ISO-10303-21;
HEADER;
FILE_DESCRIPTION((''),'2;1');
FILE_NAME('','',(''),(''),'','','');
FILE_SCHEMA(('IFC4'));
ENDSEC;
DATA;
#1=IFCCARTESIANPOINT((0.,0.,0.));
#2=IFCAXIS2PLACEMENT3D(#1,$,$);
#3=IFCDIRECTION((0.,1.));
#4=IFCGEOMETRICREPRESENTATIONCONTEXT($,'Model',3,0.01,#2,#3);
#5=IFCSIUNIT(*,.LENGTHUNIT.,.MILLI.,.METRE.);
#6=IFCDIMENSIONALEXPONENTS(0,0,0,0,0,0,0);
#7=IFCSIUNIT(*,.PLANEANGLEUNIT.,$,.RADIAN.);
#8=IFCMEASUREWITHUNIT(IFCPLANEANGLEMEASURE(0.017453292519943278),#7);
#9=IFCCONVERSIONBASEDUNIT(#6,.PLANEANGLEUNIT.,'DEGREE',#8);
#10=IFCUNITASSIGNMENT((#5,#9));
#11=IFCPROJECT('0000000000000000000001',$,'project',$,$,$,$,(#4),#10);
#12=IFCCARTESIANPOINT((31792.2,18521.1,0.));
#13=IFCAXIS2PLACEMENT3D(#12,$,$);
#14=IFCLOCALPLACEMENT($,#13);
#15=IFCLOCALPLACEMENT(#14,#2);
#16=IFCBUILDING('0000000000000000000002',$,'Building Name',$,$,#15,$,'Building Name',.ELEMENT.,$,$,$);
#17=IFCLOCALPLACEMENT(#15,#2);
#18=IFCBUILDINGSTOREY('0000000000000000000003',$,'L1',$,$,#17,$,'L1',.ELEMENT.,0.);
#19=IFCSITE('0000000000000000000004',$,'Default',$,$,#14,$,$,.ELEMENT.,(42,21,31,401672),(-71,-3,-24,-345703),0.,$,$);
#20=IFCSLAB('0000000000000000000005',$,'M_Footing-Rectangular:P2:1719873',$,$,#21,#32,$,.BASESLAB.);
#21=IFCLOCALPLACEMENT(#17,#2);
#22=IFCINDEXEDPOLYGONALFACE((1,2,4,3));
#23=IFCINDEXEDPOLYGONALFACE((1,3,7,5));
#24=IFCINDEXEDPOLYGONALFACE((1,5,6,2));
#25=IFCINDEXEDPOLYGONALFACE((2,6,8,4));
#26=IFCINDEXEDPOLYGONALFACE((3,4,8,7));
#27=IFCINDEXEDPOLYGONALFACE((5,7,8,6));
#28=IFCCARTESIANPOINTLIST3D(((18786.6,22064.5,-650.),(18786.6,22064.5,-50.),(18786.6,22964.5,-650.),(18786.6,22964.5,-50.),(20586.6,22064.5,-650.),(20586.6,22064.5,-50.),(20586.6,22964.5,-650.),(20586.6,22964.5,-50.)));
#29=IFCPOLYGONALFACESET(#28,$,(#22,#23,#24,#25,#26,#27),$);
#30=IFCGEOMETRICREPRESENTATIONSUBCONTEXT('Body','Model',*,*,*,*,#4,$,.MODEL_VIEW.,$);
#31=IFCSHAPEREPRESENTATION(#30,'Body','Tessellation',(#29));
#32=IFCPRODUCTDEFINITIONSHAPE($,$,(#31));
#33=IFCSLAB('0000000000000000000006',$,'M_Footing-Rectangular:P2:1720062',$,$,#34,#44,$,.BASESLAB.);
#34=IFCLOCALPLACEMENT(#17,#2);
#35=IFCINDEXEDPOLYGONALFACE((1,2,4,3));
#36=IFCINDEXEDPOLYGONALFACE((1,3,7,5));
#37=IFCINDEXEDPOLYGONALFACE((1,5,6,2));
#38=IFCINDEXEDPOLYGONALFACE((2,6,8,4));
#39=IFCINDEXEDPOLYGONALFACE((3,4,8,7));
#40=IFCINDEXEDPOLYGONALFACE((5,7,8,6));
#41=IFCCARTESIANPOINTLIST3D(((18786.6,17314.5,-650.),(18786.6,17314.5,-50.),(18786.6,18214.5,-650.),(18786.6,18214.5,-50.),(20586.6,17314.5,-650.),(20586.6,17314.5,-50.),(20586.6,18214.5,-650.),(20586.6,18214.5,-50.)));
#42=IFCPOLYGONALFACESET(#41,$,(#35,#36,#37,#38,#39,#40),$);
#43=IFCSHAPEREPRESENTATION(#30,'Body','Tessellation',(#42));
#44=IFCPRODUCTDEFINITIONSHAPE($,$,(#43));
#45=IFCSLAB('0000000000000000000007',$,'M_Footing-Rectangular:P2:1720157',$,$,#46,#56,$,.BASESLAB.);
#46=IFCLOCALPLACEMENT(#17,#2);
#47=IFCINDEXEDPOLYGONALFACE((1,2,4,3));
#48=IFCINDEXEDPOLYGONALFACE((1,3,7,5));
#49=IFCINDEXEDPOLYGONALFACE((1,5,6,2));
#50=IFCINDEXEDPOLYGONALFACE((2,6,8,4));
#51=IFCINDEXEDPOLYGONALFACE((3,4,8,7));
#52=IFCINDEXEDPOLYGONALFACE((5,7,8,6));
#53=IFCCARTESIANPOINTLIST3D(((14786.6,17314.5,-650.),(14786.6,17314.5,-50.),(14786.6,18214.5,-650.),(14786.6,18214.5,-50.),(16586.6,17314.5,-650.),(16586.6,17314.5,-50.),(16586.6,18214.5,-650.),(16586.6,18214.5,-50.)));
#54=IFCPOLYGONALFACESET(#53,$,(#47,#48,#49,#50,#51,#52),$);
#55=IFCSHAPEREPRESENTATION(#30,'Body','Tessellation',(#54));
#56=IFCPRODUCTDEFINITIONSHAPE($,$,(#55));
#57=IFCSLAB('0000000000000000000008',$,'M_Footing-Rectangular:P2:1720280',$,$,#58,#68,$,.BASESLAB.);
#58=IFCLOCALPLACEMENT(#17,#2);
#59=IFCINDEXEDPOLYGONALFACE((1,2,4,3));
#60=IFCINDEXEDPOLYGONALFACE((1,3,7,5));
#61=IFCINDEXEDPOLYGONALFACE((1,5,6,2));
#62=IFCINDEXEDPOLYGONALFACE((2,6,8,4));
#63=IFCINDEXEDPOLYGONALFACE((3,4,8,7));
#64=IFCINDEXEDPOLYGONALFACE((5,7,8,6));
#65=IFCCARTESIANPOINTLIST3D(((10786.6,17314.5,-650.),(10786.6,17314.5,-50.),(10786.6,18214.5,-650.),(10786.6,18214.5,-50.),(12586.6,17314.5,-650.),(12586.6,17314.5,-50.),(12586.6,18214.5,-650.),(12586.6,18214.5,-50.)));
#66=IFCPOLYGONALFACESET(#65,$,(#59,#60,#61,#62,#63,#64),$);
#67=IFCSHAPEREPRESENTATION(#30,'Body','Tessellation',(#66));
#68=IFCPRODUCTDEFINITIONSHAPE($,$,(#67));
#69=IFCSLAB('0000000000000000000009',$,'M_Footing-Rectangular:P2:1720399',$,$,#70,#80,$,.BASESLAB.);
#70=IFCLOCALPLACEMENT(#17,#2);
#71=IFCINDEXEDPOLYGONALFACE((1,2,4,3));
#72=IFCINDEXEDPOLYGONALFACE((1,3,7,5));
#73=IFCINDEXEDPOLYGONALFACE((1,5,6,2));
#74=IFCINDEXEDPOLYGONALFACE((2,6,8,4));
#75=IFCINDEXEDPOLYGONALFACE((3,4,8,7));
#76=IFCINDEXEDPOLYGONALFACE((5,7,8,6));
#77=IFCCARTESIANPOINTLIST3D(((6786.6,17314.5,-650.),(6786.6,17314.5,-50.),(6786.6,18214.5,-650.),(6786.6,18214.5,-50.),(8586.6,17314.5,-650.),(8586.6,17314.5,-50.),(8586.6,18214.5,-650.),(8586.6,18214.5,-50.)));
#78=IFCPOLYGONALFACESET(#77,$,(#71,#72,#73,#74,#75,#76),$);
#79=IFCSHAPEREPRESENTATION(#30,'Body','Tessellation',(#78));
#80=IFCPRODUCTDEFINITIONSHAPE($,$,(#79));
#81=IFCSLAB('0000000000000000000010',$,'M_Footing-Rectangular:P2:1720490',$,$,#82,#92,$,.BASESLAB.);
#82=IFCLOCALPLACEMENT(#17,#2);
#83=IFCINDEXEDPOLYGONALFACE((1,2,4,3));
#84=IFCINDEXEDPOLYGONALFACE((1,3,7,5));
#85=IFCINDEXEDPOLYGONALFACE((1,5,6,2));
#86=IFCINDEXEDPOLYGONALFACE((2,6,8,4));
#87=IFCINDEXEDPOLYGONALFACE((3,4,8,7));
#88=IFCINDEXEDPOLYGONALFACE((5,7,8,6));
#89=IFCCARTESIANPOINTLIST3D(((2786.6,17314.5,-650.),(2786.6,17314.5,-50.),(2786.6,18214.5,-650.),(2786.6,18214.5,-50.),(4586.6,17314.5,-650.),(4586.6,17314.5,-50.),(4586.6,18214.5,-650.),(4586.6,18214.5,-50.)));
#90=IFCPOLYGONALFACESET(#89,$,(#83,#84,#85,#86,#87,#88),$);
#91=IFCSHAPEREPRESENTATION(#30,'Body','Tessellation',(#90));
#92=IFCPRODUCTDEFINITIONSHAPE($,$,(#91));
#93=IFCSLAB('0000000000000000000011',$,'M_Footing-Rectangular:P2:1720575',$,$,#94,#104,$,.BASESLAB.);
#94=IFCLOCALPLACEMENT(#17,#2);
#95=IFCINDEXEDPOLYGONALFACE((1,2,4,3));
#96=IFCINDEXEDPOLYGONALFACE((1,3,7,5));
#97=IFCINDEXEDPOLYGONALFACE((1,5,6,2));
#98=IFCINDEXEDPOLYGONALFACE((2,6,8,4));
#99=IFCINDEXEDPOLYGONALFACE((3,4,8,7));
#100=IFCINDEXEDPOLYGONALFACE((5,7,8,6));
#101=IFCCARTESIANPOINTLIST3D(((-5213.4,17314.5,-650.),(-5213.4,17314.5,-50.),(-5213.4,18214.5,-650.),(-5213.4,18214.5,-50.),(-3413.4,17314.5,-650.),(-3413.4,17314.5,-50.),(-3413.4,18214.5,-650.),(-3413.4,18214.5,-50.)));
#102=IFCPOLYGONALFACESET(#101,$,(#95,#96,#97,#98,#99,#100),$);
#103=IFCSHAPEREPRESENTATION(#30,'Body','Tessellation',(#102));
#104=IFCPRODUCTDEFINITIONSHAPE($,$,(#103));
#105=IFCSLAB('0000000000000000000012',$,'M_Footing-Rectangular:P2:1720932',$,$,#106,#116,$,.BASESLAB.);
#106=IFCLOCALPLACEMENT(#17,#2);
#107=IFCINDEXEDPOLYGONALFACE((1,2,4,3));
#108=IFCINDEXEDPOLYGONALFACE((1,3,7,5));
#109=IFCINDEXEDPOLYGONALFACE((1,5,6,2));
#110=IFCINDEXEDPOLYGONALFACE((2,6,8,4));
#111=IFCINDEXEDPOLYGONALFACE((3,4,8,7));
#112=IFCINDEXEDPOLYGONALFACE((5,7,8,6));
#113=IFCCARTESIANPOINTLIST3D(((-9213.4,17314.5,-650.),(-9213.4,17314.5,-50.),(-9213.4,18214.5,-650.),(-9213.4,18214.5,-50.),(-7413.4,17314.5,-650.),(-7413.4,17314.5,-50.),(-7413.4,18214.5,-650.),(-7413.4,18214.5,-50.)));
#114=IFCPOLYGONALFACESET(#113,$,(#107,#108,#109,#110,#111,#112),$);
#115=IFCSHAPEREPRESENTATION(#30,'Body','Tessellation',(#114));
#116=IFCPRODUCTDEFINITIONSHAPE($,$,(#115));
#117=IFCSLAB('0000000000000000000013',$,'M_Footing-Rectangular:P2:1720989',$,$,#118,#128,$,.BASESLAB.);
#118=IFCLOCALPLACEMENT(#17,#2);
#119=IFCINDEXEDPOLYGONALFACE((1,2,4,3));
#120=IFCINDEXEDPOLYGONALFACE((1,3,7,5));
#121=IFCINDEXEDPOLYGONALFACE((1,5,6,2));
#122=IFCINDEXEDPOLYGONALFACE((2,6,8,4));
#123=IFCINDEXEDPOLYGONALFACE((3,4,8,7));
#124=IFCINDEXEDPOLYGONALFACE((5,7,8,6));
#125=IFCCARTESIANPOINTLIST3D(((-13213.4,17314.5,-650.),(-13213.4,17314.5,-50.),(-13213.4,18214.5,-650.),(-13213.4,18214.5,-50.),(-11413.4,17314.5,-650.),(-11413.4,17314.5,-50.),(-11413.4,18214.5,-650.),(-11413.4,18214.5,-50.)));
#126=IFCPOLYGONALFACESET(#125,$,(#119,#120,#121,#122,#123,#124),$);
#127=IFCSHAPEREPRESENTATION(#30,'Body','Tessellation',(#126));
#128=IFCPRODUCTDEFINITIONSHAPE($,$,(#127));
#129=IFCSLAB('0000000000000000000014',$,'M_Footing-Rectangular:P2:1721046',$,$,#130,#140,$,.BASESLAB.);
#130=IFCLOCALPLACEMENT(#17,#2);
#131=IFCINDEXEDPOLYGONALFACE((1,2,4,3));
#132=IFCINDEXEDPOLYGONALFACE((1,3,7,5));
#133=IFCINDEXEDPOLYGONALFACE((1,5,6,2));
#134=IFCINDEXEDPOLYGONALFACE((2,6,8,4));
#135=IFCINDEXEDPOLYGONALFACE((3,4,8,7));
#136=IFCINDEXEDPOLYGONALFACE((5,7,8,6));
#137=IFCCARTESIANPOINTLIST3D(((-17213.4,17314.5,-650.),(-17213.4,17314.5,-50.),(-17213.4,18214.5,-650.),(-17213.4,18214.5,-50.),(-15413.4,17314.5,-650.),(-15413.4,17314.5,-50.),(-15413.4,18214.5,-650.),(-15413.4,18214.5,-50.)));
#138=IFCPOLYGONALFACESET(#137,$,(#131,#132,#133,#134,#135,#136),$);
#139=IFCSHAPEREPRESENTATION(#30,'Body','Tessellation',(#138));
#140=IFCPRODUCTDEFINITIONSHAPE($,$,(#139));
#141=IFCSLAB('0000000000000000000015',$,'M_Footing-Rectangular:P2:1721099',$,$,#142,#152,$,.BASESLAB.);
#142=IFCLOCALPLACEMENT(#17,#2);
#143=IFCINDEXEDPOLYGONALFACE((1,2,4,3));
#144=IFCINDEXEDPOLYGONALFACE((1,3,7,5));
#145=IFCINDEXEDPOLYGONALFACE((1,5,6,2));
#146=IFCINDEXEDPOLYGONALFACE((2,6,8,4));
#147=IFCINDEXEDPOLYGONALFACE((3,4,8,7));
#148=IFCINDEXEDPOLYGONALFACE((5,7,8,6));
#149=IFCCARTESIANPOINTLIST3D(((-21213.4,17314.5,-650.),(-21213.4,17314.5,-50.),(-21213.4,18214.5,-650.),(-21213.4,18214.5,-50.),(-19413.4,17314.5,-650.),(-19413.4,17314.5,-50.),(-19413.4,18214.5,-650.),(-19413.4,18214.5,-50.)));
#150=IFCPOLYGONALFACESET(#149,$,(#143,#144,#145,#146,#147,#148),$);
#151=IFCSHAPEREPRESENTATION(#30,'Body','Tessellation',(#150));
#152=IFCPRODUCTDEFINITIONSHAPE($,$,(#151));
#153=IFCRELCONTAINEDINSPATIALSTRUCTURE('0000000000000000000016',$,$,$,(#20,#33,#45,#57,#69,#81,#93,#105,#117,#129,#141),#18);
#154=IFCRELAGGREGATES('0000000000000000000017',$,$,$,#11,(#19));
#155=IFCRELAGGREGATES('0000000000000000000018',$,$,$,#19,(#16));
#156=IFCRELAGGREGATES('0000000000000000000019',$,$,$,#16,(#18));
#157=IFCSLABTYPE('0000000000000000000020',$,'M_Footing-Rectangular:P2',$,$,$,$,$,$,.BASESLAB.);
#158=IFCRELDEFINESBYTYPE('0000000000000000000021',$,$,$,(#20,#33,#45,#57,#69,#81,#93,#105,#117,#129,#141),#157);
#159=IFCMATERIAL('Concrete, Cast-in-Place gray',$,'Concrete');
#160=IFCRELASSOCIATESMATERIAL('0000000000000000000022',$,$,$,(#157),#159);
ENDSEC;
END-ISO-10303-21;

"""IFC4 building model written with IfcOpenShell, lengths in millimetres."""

from ifc_helpers import new_model, entity, si_unit, converted_unit, direction, frame, origin, place, context, subcontext, project, spatial, indexed_curve, outline, extrude, material, type_object, element, save


model = new_model("IFC4")

# Units and contexts
model_context = context("Model", 3, precision=0.01, world=origin(), true_north=direction((0.0, 1.0)))
body_context = subcontext(model_context, "Body", "Model", "MODEL_VIEW")
ifc_project = project(units=[si_unit("LENGTHUNIT", "METRE", prefix="MILLI"), converted_unit("PLANEANGLEUNIT", "DEGREE", entity("IfcPlaneAngleMeasure", 0.017453292519943278), si_unit("PLANEANGLEUNIT", "RADIAN"), dimensions=[0, 0, 0, 0, 0, 0, 0])], contexts=[model_context])

# Site, building, storey
site_placement = place(None, frame((31792.2, 18521.1, 0.0)))
site = spatial("IfcSite", under=ifc_project, at=site_placement, Name="Default", CompositionType="ELEMENT", RefLatitude=(42, 21, 31, 401672), RefLongitude=(-71, -3, -24, -345703), RefElevation=0.0)
building_placement = place(site_placement, origin())
building = spatial("IfcBuilding", under=site, at=building_placement, Name="Building Name", LongName="Building Name", CompositionType="ELEMENT")
storey_placement = place(building_placement, origin())
storey = spatial("IfcBuildingStorey", under=building, at=storey_placement, Name="L1", LongName="L1", CompositionType="ELEMENT", Elevation=0.0)

# Shared definitions
ifc_material = material(Name="Concrete, Cast-in-Place gray", Category="Concrete")

# Slabs
slab_type = type_object("IfcSlabType", Name="M_Footing-Rectangular:P2", PredefinedType="BASESLAB", material=ifc_material)
slab_1_placement = place(storey_placement, origin())
element("IfcSlab", 1, at=slab_1_placement, inside=storey, type_object=slab_type, Name="M_Footing-Rectangular:P2:1719873", PredefinedType="BASESLAB", context=body_context, shape_type="SweptSolid", body=[
    extrude(outline(indexed_curve([(-450.0, -900.0), (450.0, -900.0), (450.0, 900.0), (-450.0, 900.0), (-450.0, -900.0)], self_intersect=False)), frame((19686.6, 22514.5, -650.0), z_axis=(0.0, 0.0, 1.0), x_axis=(0.0, -1.0, 0.0)), (0.0, 0.0, 1.0), 600.0),
])
slab_2_placement = place(storey_placement, origin())
element("IfcSlab", 2, at=slab_2_placement, inside=storey, type_object=slab_type, Name="M_Footing-Rectangular:P2:1720062", PredefinedType="BASESLAB", context=body_context, shape_type="SweptSolid", body=[
    extrude(outline(indexed_curve([(-450.0, -900.0), (450.0, -900.0), (450.0, 900.0), (-450.0, 900.0), (-450.0, -900.0)], self_intersect=False)), frame((19686.6, 17764.5, -650.0), z_axis=(0.0, 0.0, 1.0), x_axis=(0.0, -1.0, 0.0)), (0.0, 0.0, 1.0), 600.0),
])
slab_3_placement = place(storey_placement, origin())
element("IfcSlab", 3, at=slab_3_placement, inside=storey, type_object=slab_type, Name="M_Footing-Rectangular:P2:1720157", PredefinedType="BASESLAB", context=body_context, shape_type="SweptSolid", body=[
    extrude(outline(indexed_curve([(-450.0, -900.0), (450.0, -900.0), (450.0, 900.0), (-450.0, 900.0), (-450.0, -900.0)], self_intersect=False)), frame((15686.6, 17764.5, -650.0), z_axis=(0.0, 0.0, 1.0), x_axis=(0.0, -1.0, 0.0)), (0.0, 0.0, 1.0), 600.0),
])
slab_4_placement = place(storey_placement, origin())
element("IfcSlab", 4, at=slab_4_placement, inside=storey, type_object=slab_type, Name="M_Footing-Rectangular:P2:1720280", PredefinedType="BASESLAB", context=body_context, shape_type="SweptSolid", body=[
    extrude(outline(indexed_curve([(-450.0, -900.0), (450.0, -900.0), (450.0, 900.0), (-450.0, 900.0), (-450.0, -900.0)], self_intersect=False)), frame((11686.6, 17764.5, -650.0), z_axis=(0.0, 0.0, 1.0), x_axis=(0.0, -1.0, 0.0)), (0.0, 0.0, 1.0), 600.0),
])
slab_5_placement = place(storey_placement, origin())
element("IfcSlab", 5, at=slab_5_placement, inside=storey, type_object=slab_type, Name="M_Footing-Rectangular:P2:1720399", PredefinedType="BASESLAB", context=body_context, shape_type="SweptSolid", body=[
    extrude(outline(indexed_curve([(-450.0, -900.0), (450.0, -900.0), (450.0, 900.0), (-450.0, 900.0), (-450.0, -900.0)], self_intersect=False)), frame((7686.6, 17764.5, -650.0), z_axis=(0.0, 0.0, 1.0), x_axis=(0.0, -1.0, 0.0)), (0.0, 0.0, 1.0), 600.0),
])
slab_6_placement = place(storey_placement, origin())
element("IfcSlab", 6, at=slab_6_placement, inside=storey, type_object=slab_type, Name="M_Footing-Rectangular:P2:1720490", PredefinedType="BASESLAB", context=body_context, shape_type="SweptSolid", body=[
    extrude(outline(indexed_curve([(-450.0, -900.0), (450.0, -900.0), (450.0, 900.0), (-450.0, 900.0), (-450.0, -900.0)], self_intersect=False)), frame((3686.6, 17764.5, -650.0), z_axis=(0.0, 0.0, 1.0), x_axis=(0.0, -1.0, 0.0)), (0.0, 0.0, 1.0), 600.0),
])
slab_7_placement = place(storey_placement, origin())
element("IfcSlab", 7, at=slab_7_placement, inside=storey, type_object=slab_type, Name="M_Footing-Rectangular:P2:1720575", PredefinedType="BASESLAB", context=body_context, shape_type="SweptSolid", body=[
    extrude(outline(indexed_curve([(-450.0, -900.0), (450.0, -900.0), (450.0, 900.0), (-450.0, 900.0), (-450.0, -900.0)], self_intersect=False)), frame((-4313.4, 17764.5, -650.0), z_axis=(0.0, 0.0, 1.0), x_axis=(0.0, -1.0, 0.0)), (0.0, 0.0, 1.0), 600.0),
])
slab_8_placement = place(storey_placement, origin())
element("IfcSlab", 8, at=slab_8_placement, inside=storey, type_object=slab_type, Name="M_Footing-Rectangular:P2:1720932", PredefinedType="BASESLAB", context=body_context, shape_type="SweptSolid", body=[
    extrude(outline(indexed_curve([(-450.0, -900.0), (450.0, -900.0), (450.0, 900.0), (-450.0, 900.0), (-450.0, -900.0)], self_intersect=False)), frame((-8313.4, 17764.5, -650.0), z_axis=(0.0, 0.0, 1.0), x_axis=(0.0, -1.0, 0.0)), (0.0, 0.0, 1.0), 600.0),
])
slab_9_placement = place(storey_placement, origin())
element("IfcSlab", 9, at=slab_9_placement, inside=storey, type_object=slab_type, Name="M_Footing-Rectangular:P2:1720989", PredefinedType="BASESLAB", context=body_context, shape_type="SweptSolid", body=[
    extrude(outline(indexed_curve([(-450.0, -900.0), (450.0, -900.0), (450.0, 900.0), (-450.0, 900.0), (-450.0, -900.0)], self_intersect=False)), frame((-12313.4, 17764.5, -650.0), z_axis=(0.0, 0.0, 1.0), x_axis=(0.0, -1.0, 0.0)), (0.0, 0.0, 1.0), 600.0),
])
slab_10_placement = place(storey_placement, origin())
element("IfcSlab", 10, at=slab_10_placement, inside=storey, type_object=slab_type, Name="M_Footing-Rectangular:P2:1721046", PredefinedType="BASESLAB", context=body_context, shape_type="SweptSolid", body=[
    extrude(outline(indexed_curve([(-450.0, -900.0), (450.0, -900.0), (450.0, 900.0), (-450.0, 900.0), (-450.0, -900.0)], self_intersect=False)), frame((-16313.4, 17764.5, -650.0), z_axis=(0.0, 0.0, 1.0), x_axis=(0.0, -1.0, 0.0)), (0.0, 0.0, 1.0), 600.0),
])
slab_11_placement = place(storey_placement, origin())
element("IfcSlab", 11, at=slab_11_placement, inside=storey, type_object=slab_type, Name="M_Footing-Rectangular:P2:1721099", PredefinedType="BASESLAB", context=body_context, shape_type="SweptSolid", body=[
    extrude(outline(indexed_curve([(-450.0, -900.0), (450.0, -900.0), (450.0, 900.0), (-450.0, 900.0), (-450.0, -900.0)], self_intersect=False)), frame((-20313.4, 17764.5, -650.0), z_axis=(0.0, 0.0, 1.0), x_axis=(0.0, -1.0, 0.0)), (0.0, 0.0, 1.0), 600.0),
])

save(model, "model.ifc")
